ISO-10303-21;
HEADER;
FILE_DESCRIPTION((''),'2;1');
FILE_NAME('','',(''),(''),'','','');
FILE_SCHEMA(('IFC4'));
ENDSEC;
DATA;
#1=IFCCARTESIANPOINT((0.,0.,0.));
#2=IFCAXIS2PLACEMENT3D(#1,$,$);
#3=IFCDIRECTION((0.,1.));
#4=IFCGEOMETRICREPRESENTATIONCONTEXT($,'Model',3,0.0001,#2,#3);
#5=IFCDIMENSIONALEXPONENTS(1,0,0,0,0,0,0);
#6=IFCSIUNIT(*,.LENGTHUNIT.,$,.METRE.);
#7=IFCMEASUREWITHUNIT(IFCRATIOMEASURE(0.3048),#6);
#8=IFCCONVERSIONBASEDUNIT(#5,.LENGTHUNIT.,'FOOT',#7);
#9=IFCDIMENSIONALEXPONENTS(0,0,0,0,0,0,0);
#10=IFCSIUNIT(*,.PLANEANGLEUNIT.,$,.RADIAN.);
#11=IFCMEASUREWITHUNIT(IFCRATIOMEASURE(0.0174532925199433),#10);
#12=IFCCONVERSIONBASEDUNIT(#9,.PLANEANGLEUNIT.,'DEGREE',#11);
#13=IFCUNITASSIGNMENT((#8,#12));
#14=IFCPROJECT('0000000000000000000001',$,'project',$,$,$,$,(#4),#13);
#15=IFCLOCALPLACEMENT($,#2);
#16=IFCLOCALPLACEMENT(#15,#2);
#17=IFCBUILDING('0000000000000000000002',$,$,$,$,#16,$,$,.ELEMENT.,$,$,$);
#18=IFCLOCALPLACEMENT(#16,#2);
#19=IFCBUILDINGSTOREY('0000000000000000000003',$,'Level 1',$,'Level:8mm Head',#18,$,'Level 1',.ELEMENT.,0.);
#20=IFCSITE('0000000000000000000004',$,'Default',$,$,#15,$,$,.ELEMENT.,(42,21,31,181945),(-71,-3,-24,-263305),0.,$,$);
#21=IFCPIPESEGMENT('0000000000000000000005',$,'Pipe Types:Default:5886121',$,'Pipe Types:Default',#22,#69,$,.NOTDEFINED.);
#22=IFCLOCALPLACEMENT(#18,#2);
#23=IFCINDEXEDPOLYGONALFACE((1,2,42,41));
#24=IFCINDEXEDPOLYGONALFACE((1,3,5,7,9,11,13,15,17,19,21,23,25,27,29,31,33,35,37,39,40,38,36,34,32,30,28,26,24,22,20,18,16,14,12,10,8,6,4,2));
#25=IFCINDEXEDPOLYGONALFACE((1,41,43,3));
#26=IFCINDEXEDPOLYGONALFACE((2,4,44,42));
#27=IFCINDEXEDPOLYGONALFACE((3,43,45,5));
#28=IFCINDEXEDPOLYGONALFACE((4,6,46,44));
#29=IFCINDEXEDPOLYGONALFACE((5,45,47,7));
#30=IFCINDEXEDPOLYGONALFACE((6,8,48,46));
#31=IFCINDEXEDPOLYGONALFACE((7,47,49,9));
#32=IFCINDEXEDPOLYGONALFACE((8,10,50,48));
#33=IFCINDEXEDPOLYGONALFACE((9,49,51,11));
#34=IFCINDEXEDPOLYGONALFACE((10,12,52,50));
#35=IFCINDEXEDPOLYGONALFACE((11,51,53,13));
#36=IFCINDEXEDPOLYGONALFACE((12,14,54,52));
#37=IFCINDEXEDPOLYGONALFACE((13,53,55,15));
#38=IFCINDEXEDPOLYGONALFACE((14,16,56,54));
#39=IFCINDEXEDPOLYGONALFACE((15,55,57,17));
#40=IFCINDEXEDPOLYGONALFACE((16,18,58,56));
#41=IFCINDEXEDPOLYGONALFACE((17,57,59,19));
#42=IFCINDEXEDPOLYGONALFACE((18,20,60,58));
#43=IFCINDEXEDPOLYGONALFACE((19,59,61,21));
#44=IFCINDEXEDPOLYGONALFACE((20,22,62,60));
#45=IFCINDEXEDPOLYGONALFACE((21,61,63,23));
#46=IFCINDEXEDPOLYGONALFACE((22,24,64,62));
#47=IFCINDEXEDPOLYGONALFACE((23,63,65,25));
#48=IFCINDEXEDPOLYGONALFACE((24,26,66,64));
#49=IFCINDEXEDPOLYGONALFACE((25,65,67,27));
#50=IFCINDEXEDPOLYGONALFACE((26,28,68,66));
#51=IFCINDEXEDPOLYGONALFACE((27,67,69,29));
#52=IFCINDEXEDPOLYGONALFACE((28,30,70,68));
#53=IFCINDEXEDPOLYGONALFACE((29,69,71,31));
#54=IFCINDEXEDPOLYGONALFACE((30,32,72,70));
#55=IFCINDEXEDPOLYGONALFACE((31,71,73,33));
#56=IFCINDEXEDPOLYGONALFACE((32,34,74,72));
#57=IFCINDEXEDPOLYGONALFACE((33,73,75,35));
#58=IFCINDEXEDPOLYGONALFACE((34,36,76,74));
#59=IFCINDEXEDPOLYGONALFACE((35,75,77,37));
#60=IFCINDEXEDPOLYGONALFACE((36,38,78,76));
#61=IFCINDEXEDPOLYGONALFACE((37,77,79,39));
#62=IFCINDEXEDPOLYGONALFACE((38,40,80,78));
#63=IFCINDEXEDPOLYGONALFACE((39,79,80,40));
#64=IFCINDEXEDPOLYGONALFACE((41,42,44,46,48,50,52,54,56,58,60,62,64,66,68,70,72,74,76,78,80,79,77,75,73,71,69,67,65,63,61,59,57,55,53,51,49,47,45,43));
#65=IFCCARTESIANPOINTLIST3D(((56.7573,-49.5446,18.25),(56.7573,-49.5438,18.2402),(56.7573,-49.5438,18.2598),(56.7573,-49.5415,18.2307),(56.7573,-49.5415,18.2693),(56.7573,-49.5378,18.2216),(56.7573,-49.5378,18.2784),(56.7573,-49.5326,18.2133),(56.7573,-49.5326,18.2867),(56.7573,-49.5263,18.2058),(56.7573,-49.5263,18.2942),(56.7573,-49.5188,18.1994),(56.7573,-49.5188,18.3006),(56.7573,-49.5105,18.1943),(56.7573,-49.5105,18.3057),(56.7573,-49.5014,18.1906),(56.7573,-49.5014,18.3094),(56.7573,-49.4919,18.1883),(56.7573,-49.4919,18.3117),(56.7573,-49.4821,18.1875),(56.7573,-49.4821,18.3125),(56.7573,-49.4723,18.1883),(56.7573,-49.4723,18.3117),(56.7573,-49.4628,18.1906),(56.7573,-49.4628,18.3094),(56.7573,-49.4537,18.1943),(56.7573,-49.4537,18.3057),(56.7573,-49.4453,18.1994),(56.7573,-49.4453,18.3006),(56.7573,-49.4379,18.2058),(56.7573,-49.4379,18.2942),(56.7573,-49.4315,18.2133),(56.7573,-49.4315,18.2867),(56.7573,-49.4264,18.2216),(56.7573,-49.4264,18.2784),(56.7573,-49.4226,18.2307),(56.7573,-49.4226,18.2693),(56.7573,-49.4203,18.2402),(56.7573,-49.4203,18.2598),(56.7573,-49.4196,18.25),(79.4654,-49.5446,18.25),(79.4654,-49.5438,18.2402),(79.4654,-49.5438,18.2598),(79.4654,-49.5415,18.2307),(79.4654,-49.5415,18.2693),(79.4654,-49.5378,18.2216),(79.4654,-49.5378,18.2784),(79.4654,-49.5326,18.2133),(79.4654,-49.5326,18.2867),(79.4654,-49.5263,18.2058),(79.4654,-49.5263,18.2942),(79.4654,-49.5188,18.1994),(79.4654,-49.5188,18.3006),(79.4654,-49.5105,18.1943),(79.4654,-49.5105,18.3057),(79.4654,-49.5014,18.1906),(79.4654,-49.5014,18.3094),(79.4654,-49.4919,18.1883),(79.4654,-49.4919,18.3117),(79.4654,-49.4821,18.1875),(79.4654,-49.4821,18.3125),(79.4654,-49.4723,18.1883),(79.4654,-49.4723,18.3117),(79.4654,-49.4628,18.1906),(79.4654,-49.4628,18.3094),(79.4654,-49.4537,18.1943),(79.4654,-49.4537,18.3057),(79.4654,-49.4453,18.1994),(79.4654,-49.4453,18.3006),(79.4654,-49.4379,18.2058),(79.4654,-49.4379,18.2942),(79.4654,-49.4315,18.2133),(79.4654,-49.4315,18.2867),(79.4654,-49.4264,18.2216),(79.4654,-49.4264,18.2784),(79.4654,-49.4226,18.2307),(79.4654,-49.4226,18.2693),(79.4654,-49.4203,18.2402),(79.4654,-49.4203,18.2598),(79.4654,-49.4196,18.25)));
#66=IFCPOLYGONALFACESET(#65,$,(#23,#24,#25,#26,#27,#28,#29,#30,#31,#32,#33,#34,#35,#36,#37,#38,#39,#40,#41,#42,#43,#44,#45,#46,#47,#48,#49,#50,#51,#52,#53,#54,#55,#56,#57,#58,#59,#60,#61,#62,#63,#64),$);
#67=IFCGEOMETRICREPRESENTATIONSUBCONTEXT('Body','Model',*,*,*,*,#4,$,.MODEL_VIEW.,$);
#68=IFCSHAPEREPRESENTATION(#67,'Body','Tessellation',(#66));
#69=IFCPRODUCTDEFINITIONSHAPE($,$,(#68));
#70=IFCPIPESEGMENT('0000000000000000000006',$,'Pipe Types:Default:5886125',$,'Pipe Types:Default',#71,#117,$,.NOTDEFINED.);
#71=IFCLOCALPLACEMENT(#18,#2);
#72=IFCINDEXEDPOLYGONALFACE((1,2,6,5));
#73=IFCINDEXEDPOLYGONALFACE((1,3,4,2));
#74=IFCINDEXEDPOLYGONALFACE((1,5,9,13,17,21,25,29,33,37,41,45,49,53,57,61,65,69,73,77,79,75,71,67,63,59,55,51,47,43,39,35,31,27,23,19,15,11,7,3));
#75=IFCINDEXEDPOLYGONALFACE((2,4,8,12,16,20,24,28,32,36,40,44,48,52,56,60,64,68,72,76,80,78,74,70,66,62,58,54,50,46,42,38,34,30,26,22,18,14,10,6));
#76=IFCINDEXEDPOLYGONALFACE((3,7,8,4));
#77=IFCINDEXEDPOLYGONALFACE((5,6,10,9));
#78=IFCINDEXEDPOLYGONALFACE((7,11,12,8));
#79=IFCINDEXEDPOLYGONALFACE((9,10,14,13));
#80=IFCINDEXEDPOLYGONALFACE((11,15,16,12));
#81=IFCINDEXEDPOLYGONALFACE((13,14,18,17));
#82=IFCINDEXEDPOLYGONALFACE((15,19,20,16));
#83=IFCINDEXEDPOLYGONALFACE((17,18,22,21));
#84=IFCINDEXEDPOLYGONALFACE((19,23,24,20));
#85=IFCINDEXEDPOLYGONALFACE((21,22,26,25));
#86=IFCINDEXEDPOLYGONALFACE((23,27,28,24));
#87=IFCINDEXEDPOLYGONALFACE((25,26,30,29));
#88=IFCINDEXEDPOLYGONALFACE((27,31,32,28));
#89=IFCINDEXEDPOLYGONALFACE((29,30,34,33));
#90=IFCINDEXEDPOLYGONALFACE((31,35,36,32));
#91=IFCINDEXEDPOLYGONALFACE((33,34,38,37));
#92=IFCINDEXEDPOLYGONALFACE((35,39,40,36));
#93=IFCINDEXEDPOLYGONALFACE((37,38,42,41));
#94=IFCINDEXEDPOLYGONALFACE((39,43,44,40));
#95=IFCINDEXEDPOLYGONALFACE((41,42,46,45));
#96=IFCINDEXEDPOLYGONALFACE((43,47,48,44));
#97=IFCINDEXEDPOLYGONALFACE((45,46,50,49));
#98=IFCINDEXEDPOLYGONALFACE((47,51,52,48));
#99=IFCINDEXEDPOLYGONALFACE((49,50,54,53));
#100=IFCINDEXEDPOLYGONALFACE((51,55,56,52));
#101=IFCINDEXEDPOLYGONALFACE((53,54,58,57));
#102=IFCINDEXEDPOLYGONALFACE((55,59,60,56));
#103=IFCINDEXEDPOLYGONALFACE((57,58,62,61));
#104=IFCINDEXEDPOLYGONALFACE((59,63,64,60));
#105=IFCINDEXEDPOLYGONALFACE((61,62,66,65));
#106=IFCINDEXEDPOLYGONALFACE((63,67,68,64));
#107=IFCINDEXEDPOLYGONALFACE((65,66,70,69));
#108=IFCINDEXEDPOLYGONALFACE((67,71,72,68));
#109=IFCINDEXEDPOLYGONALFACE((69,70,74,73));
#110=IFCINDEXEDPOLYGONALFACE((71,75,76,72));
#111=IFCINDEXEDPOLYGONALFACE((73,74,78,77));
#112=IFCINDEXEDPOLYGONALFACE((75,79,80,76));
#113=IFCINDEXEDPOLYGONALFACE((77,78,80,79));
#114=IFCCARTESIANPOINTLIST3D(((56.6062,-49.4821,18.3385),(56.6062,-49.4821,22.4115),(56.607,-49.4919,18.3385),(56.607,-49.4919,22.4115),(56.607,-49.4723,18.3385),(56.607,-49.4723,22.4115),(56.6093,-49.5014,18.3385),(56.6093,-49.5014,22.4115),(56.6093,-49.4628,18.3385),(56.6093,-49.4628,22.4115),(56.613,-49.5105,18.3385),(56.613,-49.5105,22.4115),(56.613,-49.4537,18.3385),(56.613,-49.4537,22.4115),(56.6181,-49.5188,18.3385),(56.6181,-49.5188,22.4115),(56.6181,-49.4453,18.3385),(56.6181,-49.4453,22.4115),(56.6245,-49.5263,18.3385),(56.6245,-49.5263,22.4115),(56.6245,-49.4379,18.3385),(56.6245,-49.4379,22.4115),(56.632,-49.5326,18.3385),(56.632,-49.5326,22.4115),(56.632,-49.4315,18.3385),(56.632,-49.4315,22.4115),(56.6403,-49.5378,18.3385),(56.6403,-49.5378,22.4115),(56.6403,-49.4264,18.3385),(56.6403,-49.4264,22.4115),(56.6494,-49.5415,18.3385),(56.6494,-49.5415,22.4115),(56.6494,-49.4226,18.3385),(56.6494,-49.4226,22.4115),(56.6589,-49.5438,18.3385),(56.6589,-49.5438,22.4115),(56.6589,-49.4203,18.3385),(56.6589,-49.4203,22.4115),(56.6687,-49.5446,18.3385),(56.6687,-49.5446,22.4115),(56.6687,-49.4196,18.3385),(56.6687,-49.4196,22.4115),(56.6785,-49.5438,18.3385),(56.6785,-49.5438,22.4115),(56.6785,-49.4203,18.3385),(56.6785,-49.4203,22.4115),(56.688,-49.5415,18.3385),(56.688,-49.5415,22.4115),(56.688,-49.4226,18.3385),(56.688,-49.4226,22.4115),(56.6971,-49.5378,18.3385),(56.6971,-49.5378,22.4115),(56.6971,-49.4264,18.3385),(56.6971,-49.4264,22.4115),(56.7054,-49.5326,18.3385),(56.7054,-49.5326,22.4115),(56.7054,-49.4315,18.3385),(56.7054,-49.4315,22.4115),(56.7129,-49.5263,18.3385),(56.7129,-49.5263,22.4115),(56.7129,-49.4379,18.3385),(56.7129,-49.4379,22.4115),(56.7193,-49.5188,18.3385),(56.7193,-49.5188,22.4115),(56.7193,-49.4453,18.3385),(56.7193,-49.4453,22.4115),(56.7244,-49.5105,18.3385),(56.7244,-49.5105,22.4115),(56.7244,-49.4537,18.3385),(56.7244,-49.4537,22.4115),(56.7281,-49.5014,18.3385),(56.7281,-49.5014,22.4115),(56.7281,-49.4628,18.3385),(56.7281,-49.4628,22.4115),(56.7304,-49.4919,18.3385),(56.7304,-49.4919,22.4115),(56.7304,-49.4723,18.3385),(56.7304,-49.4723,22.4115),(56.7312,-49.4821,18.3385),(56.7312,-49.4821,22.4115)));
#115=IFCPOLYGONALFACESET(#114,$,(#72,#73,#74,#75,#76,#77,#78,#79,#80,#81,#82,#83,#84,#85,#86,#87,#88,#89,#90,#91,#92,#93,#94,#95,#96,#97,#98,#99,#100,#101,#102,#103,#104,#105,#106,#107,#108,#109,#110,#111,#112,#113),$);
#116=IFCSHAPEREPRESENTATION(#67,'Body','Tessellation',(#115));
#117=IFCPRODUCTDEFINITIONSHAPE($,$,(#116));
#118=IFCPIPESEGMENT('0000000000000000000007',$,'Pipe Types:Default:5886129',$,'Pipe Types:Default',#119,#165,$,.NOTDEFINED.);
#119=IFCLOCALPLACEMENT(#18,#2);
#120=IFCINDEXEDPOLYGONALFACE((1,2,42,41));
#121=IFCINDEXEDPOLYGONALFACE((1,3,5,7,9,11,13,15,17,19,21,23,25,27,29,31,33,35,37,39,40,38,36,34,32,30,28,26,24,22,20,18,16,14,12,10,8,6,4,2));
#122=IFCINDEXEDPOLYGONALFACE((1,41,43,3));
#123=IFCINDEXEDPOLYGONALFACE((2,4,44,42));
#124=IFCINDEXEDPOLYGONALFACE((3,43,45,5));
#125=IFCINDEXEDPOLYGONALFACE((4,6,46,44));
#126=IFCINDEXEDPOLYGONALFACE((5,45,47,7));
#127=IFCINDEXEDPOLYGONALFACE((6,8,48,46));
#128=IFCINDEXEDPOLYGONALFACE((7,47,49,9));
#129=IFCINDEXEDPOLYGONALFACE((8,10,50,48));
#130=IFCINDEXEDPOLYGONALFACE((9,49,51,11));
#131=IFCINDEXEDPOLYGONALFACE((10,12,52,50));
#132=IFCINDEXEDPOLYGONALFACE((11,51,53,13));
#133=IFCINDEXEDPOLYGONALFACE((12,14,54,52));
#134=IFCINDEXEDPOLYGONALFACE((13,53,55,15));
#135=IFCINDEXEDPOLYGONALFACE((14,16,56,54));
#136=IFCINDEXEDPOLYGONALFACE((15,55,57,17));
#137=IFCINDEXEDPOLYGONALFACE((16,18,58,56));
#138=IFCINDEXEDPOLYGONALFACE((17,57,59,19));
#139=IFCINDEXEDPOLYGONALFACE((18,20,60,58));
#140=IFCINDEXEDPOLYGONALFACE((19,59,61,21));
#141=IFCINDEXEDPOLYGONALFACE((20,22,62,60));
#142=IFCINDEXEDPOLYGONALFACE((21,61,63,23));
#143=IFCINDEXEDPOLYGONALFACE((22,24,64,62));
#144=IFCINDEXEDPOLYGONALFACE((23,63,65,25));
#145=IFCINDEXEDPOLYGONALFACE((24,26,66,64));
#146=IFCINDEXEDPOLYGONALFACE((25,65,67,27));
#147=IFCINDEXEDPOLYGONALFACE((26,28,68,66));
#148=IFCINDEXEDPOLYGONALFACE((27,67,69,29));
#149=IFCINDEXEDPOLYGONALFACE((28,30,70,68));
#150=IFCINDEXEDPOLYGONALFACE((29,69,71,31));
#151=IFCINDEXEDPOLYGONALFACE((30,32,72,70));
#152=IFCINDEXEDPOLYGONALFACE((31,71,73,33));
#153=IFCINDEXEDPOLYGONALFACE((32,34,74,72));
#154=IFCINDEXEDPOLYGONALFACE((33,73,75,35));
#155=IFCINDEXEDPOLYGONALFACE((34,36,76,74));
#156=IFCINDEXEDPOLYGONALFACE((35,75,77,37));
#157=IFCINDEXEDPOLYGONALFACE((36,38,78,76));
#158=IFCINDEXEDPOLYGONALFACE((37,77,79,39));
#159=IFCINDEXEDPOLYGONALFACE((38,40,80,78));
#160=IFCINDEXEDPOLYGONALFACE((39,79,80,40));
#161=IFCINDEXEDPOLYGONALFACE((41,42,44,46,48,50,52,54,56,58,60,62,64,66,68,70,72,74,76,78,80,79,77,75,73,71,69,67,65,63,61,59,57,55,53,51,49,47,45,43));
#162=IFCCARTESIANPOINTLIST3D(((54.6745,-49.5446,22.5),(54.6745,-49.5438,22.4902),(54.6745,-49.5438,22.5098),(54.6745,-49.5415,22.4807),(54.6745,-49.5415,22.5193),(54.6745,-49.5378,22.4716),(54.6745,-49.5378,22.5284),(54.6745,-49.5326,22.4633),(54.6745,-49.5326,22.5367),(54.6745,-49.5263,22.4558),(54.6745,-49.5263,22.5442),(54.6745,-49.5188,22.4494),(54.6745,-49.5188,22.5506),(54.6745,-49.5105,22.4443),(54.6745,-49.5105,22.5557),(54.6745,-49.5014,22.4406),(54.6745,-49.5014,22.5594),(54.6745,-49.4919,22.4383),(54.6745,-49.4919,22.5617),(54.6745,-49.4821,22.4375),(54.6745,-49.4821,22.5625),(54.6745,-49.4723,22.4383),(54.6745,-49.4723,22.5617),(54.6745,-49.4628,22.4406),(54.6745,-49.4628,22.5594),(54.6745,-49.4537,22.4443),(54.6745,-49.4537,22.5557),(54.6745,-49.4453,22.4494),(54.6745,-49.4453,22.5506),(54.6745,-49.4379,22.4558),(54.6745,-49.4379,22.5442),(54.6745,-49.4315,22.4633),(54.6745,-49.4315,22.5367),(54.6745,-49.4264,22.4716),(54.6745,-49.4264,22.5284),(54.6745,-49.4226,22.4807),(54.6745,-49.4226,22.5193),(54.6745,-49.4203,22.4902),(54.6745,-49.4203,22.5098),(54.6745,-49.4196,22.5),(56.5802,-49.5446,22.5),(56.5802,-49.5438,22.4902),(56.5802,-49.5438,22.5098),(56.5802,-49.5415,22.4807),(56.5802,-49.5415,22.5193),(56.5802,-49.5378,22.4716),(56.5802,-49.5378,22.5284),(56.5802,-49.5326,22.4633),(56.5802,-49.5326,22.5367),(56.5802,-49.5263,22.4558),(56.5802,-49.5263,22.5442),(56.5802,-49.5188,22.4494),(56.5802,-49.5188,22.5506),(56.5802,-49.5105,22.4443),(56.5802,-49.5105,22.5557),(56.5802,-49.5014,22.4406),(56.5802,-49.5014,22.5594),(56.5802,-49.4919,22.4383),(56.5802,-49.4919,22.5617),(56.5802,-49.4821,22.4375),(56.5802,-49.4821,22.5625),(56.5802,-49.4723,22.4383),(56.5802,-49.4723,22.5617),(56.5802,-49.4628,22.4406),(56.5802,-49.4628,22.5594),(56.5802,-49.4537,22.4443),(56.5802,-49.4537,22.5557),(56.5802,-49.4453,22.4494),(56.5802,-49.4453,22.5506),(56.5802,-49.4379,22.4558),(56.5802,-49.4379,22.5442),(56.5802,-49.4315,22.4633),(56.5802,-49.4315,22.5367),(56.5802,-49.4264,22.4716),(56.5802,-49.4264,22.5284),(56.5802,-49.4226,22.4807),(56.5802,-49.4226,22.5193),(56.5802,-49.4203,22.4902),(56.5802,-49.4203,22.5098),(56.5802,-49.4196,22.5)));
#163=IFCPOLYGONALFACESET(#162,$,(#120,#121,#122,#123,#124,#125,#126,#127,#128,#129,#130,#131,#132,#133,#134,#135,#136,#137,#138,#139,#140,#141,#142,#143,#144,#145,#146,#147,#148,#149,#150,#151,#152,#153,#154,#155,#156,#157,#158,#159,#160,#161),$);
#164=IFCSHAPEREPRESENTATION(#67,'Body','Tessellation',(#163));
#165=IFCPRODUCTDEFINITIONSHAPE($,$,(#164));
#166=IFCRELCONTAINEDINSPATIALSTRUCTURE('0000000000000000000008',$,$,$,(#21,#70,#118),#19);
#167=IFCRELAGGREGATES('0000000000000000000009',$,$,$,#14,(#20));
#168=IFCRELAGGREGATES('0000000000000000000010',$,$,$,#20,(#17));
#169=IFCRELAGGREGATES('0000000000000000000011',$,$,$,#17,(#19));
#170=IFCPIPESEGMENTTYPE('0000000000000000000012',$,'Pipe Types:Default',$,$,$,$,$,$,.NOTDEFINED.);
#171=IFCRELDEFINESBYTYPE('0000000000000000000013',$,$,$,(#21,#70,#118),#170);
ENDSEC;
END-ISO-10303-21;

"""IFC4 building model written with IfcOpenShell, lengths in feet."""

from ifc_helpers import new_model, entity, si_unit, converted_unit, direction, frame, origin, place, context, subcontext, project, spatial, indexed_curve, outline, extrude, type_object, element, save


model = new_model("IFC4")

# Units and contexts
model_context = context("Model", 3, precision=0.0001, world=origin(), true_north=direction((0.0, 1.0)))
body_context = subcontext(model_context, "Body", "Model", "MODEL_VIEW")
ifc_project = project(units=[converted_unit("LENGTHUNIT", "FOOT", entity("IfcRatioMeasure", 0.3048), si_unit("LENGTHUNIT", "METRE"), dimensions=[1, 0, 0, 0, 0, 0, 0]), converted_unit("PLANEANGLEUNIT", "DEGREE", entity("IfcRatioMeasure", 0.0174532925199433), si_unit("PLANEANGLEUNIT", "RADIAN"), dimensions=[0, 0, 0, 0, 0, 0, 0])], contexts=[model_context])

# Site, building, storey
site_placement = place(None, origin())
site = spatial("IfcSite", under=ifc_project, at=site_placement, Name="Default", CompositionType="ELEMENT", RefLatitude=(42, 21, 31, 181945), RefLongitude=(-71, -3, -24, -263305), RefElevation=0.0)
building_placement = place(site_placement, origin())
building = spatial("IfcBuilding", under=site, at=building_placement, CompositionType="ELEMENT")
storey_placement = place(building_placement, origin())
storey = spatial("IfcBuildingStorey", under=building, at=storey_placement, Name="Level 1", ObjectType="Level:8mm Head", LongName="Level 1", CompositionType="ELEMENT", Elevation=0.0)

# Pipe segments
pipe_segment_type = type_object("IfcPipeSegmentType", Name="Pipe Types:Default", PredefinedType="NOTDEFINED")
pipe_segment_1_placement = place(storey_placement, origin())
element("IfcPipeSegment", 1, at=pipe_segment_1_placement, inside=storey, type_object=pipe_segment_type, Name="Pipe Types:Default:5886121", ObjectType="Pipe Types:Default", PredefinedType="NOTDEFINED", context=body_context, shape_type="SweptSolid", body=[
    extrude(outline(indexed_curve([(0.0625, 0.0), (0.0617, 0.0098), (0.0594, 0.0193), (0.0557, 0.0284), (0.0506, 0.0367), (0.0442, 0.0442), (0.0367, 0.0506), (0.0284, 0.0557), (0.0193, 0.0594), (0.0098, 0.0617), (0.0, 0.0625), (-0.0098, 0.0617), (-0.0193, 0.0594), (-0.0284, 0.0557), (-0.0367, 0.0506), (-0.0442, 0.0442), (-0.0506, 0.0367), (-0.0557, 0.0284), (-0.0594, 0.0193), (-0.0617, 0.0098), (-0.0625, 0.0), (-0.0617, -0.0098), (-0.0594, -0.0193), (-0.0557, -0.0284), (-0.0506, -0.0367), (-0.0442, -0.0442), (-0.0367, -0.0506), (-0.0284, -0.0557), (-0.0193, -0.0594), (-0.0098, -0.0617), (0.0, -0.0625), (0.0098, -0.0617), (0.0193, -0.0594), (0.0284, -0.0557), (0.0367, -0.0506), (0.0442, -0.0442), (0.0506, -0.0367), (0.0557, -0.0284), (0.0594, -0.0193), (0.0617, -0.0098), (0.0625, 0.0)], self_intersect=False)), frame((56.7573, -49.4821, 18.25), z_axis=(1.0, 0.0, 0.0), x_axis=(0.0, 1.0, 0.0)), (0.0, 0.0, 1.0), 22.7081),
])
pipe_segment_2_placement = place(storey_placement, origin())
element("IfcPipeSegment", 2, at=pipe_segment_2_placement, inside=storey, type_object=pipe_segment_type, Name="Pipe Types:Default:5886125", ObjectType="Pipe Types:Default", PredefinedType="NOTDEFINED", context=body_context, shape_type="SweptSolid", body=[
    extrude(outline(indexed_curve([(0.0625, 0.0), (0.0617, 0.0098), (0.0594, 0.0193), (0.0557, 0.0284), (0.0506, 0.0367), (0.0442, 0.0442), (0.0367, 0.0506), (0.0284, 0.0557), (0.0193, 0.0594), (0.0098, 0.0617), (0.0, 0.0625), (-0.0098, 0.0617), (-0.0193, 0.0594), (-0.0284, 0.0557), (-0.0367, 0.0506), (-0.0442, 0.0442), (-0.0506, 0.0367), (-0.0557, 0.0284), (-0.0594, 0.0193), (-0.0617, 0.0098), (-0.0625, 0.0), (-0.0617, -0.0098), (-0.0594, -0.0193), (-0.0557, -0.0284), (-0.0506, -0.0367), (-0.0442, -0.0442), (-0.0367, -0.0506), (-0.0284, -0.0557), (-0.0193, -0.0594), (-0.0098, -0.0617), (0.0, -0.0625), (0.0098, -0.0617), (0.0193, -0.0594), (0.0284, -0.0557), (0.0367, -0.0506), (0.0442, -0.0442), (0.0506, -0.0367), (0.0557, -0.0284), (0.0594, -0.0193), (0.0617, -0.0098), (0.0625, 0.0)], self_intersect=False)), frame((56.6687, -49.4821, 18.3385), z_axis=(0.0, 0.0, 1.0), x_axis=(-1.0, 0.0, 0.0)), (0.0, 0.0, 1.0), 4.0729),
])
pipe_segment_3_placement = place(storey_placement, origin())
element("IfcPipeSegment", 3, at=pipe_segment_3_placement, inside=storey, type_object=pipe_segment_type, Name="Pipe Types:Default:5886129", ObjectType="Pipe Types:Default", PredefinedType="NOTDEFINED", context=body_context, shape_type="SweptSolid", body=[
    extrude(outline(indexed_curve([(0.0625, 0.0), (0.0617, 0.0098), (0.0594, 0.0193), (0.0557, 0.0284), (0.0506, 0.0367), (0.0442, 0.0442), (0.0367, 0.0506), (0.0284, 0.0557), (0.0193, 0.0594), (0.0098, 0.0617), (0.0, 0.0625), (-0.0098, 0.0617), (-0.0193, 0.0594), (-0.0284, 0.0557), (-0.0367, 0.0506), (-0.0442, 0.0442), (-0.0506, 0.0367), (-0.0557, 0.0284), (-0.0594, 0.0193), (-0.0617, 0.0098), (-0.0625, 0.0), (-0.0617, -0.0098), (-0.0594, -0.0193), (-0.0557, -0.0284), (-0.0506, -0.0367), (-0.0442, -0.0442), (-0.0367, -0.0506), (-0.0284, -0.0557), (-0.0193, -0.0594), (-0.0098, -0.0617), (0.0, -0.0625), (0.0098, -0.0617), (0.0193, -0.0594), (0.0284, -0.0557), (0.0367, -0.0506), (0.0442, -0.0442), (0.0506, -0.0367), (0.0557, -0.0284), (0.0594, -0.0193), (0.0617, -0.0098), (0.0625, 0.0)], self_intersect=False)), frame((54.6745, -49.4821, 22.5), z_axis=(1.0, 0.0, 0.0), x_axis=(0.0, 1.0, 0.0)), (0.0, 0.0, 1.0), 1.9057),
])

save(model, "model.ifc")
